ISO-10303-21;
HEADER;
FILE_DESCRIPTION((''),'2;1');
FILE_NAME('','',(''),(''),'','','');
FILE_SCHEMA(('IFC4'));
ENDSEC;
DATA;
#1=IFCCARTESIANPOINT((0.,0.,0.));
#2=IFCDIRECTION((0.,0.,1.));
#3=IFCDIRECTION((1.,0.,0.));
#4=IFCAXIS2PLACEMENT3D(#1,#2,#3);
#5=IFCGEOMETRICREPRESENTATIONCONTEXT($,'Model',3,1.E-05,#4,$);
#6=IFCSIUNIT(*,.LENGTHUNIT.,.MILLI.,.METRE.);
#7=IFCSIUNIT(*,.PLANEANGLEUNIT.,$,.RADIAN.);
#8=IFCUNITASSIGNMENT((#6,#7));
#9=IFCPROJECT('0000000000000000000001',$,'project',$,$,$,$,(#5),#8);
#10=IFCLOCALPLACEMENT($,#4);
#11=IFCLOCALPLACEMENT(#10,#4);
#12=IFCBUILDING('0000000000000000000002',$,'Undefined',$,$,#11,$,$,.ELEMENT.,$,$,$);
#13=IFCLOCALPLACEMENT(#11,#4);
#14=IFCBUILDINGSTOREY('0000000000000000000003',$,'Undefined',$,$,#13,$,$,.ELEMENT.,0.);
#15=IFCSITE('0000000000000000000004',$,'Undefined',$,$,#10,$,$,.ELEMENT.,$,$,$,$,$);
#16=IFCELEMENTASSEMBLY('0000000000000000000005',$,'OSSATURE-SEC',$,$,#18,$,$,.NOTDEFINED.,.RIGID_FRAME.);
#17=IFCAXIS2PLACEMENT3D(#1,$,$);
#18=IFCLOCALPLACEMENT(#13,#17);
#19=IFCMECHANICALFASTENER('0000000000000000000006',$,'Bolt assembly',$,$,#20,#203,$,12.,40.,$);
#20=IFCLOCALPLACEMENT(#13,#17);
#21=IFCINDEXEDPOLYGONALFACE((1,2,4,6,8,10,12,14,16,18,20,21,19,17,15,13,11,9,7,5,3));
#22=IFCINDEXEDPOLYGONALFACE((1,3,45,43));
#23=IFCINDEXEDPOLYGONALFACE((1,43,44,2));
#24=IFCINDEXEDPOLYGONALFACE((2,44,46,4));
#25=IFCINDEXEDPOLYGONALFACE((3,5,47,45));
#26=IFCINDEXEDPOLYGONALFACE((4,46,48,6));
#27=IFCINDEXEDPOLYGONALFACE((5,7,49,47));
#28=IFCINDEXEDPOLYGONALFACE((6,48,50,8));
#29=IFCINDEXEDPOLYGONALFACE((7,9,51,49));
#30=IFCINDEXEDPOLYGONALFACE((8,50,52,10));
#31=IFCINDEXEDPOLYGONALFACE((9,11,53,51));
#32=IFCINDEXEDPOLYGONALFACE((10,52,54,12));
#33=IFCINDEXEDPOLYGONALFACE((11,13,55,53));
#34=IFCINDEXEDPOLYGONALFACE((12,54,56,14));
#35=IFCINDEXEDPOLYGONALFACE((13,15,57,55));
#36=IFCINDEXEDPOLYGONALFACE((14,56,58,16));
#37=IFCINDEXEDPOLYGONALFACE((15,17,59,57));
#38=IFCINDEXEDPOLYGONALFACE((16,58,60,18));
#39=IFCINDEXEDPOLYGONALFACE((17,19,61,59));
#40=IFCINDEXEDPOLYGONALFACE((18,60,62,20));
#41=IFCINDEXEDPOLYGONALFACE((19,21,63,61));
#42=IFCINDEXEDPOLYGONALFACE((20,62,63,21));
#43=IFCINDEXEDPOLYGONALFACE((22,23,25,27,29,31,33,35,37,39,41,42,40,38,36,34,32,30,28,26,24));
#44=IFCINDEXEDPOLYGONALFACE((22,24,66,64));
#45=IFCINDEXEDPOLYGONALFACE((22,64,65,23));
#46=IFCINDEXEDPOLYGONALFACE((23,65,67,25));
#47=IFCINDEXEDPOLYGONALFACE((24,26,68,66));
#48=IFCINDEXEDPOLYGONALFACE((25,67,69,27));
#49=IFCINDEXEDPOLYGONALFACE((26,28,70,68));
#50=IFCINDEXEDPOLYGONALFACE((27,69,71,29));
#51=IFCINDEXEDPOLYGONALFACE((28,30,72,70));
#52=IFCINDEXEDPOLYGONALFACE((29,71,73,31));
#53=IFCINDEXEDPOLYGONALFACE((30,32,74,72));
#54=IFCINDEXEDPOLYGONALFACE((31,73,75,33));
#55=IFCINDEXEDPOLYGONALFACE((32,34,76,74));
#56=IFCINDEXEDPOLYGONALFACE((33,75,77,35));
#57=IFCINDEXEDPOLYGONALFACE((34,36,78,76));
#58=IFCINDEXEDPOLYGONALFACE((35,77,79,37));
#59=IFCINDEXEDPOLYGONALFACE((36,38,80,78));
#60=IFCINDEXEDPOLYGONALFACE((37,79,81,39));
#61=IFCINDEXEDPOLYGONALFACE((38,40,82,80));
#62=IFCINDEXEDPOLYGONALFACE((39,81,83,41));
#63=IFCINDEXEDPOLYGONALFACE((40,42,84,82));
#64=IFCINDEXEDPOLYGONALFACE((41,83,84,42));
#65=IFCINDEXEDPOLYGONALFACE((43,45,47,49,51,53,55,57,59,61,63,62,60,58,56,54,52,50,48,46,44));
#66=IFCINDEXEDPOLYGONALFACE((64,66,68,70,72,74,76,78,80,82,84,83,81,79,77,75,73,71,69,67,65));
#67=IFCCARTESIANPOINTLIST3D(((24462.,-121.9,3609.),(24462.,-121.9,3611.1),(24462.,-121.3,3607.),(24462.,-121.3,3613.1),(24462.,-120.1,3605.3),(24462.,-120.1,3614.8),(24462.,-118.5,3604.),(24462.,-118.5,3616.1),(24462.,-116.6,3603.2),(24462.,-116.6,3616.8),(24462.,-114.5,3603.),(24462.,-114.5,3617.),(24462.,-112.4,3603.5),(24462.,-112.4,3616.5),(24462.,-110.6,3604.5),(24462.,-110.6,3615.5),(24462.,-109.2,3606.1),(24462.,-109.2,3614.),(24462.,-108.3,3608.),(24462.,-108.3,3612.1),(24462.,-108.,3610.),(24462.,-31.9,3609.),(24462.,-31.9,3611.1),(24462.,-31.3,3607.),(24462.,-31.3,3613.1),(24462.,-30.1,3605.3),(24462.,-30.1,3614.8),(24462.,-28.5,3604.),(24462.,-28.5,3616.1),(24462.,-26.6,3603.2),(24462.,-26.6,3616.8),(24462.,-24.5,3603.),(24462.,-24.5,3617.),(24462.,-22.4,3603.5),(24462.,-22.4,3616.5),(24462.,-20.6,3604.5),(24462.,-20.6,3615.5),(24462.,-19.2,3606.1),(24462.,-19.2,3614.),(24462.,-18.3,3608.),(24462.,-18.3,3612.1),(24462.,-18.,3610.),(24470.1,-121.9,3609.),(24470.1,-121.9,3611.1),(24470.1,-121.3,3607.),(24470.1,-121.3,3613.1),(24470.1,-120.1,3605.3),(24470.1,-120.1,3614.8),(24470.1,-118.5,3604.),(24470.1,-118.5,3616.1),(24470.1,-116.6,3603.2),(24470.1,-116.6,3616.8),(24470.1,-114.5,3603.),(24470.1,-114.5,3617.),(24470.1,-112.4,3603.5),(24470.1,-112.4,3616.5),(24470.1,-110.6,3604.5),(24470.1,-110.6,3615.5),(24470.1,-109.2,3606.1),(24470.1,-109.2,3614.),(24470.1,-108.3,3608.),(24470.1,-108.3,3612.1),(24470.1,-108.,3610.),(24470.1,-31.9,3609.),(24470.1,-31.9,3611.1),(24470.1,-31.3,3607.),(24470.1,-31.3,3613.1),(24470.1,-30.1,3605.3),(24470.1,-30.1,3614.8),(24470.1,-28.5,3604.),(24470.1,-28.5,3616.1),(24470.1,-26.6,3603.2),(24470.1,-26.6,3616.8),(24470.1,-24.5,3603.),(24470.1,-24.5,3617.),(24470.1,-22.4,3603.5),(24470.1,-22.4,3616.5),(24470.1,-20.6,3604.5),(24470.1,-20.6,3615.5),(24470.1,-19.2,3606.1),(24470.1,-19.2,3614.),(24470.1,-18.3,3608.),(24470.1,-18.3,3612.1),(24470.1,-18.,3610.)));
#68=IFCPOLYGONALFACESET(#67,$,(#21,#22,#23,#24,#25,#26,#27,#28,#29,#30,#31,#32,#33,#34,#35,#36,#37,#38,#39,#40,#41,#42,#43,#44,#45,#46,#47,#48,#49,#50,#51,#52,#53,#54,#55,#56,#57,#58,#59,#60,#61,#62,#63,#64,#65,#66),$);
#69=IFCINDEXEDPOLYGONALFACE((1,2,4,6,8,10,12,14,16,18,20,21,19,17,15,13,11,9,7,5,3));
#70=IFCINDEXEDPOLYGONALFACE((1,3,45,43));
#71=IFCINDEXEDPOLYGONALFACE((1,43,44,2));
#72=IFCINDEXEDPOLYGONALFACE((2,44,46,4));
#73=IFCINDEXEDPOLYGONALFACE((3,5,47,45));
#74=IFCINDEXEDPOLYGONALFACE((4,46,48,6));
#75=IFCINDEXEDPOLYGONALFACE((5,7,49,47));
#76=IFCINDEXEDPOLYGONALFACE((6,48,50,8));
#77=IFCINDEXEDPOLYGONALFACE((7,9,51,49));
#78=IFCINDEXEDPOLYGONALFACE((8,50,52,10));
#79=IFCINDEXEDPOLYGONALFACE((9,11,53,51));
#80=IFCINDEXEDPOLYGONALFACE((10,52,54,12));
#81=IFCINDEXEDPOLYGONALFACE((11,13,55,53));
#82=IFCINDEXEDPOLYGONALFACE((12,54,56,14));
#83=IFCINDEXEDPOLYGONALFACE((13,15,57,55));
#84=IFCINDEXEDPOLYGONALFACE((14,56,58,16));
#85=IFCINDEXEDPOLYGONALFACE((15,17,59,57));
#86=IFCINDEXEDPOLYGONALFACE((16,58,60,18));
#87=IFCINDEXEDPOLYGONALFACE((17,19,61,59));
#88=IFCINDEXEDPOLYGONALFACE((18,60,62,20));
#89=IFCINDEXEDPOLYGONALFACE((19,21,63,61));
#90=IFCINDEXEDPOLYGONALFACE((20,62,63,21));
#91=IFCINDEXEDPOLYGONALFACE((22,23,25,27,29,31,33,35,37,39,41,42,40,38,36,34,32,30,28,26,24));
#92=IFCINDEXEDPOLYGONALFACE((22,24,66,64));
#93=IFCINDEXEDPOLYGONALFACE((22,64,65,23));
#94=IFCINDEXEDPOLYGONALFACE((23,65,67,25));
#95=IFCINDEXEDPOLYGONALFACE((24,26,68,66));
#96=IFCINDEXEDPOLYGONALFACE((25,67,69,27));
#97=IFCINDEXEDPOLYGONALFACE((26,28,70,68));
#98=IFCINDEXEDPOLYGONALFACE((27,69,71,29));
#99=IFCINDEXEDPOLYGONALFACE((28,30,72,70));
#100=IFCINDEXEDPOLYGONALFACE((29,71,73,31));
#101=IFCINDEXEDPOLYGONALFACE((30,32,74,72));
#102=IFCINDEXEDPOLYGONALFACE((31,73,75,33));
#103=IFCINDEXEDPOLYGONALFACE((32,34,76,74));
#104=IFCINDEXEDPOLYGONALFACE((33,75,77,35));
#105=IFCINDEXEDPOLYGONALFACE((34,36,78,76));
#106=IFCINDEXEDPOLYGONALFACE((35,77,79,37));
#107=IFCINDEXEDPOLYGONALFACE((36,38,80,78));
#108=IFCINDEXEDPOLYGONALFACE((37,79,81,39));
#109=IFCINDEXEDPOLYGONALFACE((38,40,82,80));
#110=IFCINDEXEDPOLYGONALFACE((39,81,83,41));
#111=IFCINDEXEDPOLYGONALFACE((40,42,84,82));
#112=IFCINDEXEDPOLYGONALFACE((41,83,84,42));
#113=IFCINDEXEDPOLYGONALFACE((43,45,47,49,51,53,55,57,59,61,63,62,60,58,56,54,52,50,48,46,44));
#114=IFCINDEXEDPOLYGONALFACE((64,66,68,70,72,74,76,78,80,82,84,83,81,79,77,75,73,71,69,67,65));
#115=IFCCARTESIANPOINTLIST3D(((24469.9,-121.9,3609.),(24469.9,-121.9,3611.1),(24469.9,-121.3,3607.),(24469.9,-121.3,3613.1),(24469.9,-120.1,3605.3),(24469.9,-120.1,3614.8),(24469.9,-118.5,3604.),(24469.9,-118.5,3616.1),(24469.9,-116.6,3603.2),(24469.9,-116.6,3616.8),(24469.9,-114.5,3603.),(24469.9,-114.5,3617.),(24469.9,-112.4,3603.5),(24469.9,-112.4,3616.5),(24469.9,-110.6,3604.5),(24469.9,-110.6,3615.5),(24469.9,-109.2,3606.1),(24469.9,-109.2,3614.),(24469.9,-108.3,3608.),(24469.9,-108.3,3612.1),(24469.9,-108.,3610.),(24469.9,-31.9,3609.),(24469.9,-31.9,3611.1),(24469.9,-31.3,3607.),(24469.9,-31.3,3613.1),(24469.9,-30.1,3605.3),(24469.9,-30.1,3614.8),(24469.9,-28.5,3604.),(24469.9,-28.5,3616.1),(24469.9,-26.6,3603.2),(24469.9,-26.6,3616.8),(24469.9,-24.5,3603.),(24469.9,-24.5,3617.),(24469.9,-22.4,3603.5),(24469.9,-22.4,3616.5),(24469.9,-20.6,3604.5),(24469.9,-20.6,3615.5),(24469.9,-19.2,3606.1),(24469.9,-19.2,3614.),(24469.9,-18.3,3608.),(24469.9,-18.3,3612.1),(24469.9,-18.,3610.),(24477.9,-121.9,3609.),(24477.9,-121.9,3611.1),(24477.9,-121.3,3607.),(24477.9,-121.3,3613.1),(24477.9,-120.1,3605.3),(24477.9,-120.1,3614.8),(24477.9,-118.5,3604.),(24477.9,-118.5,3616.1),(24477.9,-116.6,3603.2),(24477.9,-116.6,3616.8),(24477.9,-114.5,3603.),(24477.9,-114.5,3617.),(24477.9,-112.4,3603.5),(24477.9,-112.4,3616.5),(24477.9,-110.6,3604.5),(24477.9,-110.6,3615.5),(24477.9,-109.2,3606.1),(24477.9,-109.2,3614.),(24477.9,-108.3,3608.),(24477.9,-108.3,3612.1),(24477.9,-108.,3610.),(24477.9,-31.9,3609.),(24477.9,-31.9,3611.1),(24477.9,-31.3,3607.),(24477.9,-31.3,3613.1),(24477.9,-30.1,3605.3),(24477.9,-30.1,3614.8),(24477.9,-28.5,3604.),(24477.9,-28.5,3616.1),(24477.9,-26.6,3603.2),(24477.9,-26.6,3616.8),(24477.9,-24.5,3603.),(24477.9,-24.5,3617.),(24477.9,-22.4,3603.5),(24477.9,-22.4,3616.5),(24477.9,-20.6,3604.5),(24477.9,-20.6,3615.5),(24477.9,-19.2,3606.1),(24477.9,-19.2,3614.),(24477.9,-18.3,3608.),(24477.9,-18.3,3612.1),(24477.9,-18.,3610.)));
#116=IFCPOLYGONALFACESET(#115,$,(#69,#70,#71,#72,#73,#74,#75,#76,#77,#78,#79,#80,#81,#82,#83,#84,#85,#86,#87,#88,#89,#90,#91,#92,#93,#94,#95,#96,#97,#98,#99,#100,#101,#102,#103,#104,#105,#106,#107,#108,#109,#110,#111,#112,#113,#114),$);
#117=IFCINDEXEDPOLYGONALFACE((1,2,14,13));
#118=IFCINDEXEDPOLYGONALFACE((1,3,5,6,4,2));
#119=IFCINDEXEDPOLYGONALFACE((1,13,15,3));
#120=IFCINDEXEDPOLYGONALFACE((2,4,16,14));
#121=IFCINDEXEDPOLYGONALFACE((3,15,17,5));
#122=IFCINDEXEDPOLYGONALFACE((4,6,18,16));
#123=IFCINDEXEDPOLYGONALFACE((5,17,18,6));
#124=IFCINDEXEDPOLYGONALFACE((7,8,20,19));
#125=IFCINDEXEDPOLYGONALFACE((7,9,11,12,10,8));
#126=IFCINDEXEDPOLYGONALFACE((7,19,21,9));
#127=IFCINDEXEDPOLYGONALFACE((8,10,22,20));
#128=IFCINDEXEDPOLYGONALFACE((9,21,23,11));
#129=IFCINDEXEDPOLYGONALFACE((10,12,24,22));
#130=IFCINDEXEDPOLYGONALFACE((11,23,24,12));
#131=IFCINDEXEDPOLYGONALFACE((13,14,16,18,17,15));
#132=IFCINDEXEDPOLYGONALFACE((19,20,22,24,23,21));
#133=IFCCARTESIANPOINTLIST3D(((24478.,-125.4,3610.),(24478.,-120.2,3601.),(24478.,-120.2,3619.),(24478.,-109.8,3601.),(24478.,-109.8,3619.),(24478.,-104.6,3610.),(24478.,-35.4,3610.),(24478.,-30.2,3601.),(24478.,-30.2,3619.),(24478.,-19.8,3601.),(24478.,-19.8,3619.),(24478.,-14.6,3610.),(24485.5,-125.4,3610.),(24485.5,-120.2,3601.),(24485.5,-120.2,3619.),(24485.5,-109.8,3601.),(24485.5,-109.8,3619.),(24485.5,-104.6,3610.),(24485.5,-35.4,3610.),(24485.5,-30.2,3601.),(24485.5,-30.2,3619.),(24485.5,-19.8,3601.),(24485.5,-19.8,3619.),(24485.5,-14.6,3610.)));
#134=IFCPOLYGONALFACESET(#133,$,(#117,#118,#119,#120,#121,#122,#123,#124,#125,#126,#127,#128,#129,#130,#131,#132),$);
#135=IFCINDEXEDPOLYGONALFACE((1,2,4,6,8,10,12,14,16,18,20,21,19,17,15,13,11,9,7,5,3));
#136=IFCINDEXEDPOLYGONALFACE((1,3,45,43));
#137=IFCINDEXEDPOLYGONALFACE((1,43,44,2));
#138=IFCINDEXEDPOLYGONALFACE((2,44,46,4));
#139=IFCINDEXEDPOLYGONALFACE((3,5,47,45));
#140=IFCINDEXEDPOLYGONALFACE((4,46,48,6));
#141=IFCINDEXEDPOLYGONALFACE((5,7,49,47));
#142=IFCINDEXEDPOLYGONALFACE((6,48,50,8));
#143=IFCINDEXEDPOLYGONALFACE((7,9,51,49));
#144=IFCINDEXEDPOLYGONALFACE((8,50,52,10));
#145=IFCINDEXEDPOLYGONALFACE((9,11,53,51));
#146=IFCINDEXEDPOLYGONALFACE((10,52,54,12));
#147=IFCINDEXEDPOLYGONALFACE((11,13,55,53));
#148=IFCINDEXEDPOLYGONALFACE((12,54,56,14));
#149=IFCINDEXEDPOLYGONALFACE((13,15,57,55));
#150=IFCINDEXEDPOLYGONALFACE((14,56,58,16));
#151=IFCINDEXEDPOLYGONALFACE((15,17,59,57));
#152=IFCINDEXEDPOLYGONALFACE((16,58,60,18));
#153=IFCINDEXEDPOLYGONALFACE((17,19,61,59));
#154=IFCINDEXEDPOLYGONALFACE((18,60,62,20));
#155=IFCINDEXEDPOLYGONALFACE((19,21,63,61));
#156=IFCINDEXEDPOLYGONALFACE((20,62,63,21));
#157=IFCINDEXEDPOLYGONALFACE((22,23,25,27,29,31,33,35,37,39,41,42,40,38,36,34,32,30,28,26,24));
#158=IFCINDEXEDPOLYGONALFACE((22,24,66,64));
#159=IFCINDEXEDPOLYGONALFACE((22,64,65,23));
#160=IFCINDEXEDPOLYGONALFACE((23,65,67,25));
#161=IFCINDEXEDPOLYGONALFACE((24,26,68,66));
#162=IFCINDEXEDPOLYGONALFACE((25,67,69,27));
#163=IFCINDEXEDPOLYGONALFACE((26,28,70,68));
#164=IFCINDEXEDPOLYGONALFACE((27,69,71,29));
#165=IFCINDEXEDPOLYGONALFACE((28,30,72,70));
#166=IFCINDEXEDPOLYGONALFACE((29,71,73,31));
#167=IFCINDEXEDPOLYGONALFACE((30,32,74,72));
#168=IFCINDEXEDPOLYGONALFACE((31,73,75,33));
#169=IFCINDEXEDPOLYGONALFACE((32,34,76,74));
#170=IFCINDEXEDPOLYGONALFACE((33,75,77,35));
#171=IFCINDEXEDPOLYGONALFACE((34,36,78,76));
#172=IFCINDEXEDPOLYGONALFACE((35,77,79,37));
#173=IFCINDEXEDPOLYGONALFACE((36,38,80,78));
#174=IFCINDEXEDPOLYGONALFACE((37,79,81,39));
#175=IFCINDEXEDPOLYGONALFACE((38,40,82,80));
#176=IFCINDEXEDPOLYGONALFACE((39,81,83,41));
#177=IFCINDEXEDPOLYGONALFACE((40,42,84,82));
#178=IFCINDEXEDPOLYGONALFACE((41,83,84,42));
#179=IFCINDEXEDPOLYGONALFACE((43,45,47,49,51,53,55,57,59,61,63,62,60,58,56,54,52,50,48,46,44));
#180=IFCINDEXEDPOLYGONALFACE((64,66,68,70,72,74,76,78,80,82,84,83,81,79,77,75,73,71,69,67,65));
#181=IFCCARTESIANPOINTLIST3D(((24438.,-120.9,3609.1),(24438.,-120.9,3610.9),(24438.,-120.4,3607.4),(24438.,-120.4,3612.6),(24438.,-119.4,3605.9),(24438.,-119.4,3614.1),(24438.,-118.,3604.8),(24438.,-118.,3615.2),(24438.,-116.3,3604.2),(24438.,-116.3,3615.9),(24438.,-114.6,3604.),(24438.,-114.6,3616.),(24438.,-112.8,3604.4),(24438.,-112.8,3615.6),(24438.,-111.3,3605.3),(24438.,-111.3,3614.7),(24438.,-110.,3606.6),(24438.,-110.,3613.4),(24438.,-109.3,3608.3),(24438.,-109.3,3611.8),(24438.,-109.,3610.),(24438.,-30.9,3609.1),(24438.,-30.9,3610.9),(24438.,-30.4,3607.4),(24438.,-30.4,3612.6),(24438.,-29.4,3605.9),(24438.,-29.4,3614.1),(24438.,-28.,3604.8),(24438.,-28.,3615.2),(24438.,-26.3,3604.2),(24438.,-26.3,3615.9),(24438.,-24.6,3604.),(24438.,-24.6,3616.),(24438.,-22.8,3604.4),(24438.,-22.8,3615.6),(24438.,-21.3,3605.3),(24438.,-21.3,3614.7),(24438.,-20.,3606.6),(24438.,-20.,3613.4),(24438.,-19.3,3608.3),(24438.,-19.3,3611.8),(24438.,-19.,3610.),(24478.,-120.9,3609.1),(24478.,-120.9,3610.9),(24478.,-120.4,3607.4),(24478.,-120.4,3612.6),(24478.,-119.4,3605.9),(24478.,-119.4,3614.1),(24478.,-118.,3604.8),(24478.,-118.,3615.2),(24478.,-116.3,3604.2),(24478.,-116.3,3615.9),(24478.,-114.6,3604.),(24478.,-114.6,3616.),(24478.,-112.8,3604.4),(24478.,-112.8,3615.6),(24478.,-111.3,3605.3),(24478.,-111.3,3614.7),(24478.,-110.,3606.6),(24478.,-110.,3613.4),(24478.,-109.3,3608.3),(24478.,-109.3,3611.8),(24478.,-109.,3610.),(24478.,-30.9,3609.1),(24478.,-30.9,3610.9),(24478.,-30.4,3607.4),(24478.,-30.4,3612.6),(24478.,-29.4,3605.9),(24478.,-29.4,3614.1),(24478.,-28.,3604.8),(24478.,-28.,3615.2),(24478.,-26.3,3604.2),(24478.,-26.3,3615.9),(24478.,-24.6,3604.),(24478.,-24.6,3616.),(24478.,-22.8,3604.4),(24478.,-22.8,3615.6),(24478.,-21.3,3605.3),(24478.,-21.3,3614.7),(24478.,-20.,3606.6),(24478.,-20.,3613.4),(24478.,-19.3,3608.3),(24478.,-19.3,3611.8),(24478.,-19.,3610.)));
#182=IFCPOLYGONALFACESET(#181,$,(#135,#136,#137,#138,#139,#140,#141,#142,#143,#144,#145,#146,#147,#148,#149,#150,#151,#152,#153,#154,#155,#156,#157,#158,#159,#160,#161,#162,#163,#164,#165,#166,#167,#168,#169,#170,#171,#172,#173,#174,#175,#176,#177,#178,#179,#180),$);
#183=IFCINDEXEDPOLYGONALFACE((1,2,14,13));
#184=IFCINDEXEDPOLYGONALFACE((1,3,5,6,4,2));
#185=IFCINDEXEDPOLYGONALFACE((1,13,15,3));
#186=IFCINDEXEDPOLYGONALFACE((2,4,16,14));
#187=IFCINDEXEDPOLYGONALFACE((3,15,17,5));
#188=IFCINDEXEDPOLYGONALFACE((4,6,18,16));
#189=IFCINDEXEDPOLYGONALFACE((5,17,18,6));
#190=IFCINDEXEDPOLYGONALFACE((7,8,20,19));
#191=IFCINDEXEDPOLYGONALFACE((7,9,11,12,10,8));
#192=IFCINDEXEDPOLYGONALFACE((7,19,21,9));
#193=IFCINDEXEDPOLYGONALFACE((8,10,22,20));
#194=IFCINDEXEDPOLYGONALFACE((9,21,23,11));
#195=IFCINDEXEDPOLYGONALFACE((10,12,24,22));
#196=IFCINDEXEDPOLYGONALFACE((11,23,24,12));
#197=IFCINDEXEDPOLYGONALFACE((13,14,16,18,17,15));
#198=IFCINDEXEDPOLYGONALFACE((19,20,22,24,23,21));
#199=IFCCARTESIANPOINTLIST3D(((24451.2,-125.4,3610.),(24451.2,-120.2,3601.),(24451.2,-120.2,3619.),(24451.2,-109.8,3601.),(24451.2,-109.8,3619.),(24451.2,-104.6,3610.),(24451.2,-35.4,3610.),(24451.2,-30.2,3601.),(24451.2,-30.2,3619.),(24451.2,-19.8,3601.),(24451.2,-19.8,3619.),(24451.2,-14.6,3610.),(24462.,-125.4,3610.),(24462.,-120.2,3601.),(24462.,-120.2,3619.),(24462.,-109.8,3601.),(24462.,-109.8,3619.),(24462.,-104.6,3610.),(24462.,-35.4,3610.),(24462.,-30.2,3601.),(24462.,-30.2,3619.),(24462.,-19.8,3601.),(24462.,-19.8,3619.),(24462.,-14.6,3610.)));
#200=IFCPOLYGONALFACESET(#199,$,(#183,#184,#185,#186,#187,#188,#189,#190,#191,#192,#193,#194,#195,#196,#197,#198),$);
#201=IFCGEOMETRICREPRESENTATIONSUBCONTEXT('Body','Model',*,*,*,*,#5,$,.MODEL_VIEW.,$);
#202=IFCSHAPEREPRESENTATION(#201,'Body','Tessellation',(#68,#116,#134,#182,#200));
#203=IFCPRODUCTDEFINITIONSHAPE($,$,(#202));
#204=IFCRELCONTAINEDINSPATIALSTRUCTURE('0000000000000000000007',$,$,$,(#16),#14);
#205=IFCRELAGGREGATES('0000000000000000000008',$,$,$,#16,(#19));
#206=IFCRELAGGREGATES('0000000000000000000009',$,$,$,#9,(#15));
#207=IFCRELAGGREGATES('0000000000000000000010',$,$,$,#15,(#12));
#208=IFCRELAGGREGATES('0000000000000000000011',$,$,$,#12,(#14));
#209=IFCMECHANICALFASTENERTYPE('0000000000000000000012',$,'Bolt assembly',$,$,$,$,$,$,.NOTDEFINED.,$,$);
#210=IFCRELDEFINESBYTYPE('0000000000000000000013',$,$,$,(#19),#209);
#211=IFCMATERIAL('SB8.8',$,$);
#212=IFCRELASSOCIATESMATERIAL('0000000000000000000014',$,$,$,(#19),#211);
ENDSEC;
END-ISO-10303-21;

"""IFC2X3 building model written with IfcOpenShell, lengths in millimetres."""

from ifc_helpers import new_model, si_unit, frame, origin_with_axes, origin_2d_with_axis, place, context, subcontext, project, spatial, polyline, circle, outline, extrude, source, transform, mapped, material, type_object, element, aggregate, save


model = new_model("IFC2X3")

# Units and contexts
model_context = context("Model", 3, precision=1e-05, world=origin_with_axes())
body_context = subcontext(model_context, "Body", "Model", "MODEL_VIEW")
ifc_project = project(units=[si_unit("LENGTHUNIT", "METRE", prefix="MILLI"), si_unit("PLANEANGLEUNIT", "RADIAN")], contexts=[model_context])

# Site, building, storey
site_placement = place(None, origin_with_axes())
site = spatial("IfcSite", under=ifc_project, at=site_placement, Name="Undefined", CompositionType="ELEMENT")
building_placement = place(site_placement, origin_with_axes())
building = spatial("IfcBuilding", under=site, at=building_placement, Name="Undefined", CompositionType="ELEMENT")
storey_placement = place(building_placement, origin_with_axes())
storey = spatial("IfcBuildingStorey", under=building, at=storey_placement, Name="Undefined", CompositionType="ELEMENT", Elevation=0.0)

# Element assembly
assembly_1_placement = place(storey_placement, origin_with_axes())
assembly_1 = element("IfcElementAssembly", 1, at=assembly_1_placement, inside=storey, Name="OSSATURE-SEC", AssemblyPlace="NOTDEFINED", PredefinedType="RIGID_FRAME")

# Mechanical fastener
ifc_material_1 = material(Name="SB8.8")
mechanical_fastener_type = type_object("IfcMechanicalFastenerType", Name="Bolt assembly")
shared_shape_1 = source(origin_with_axes(), body_context, "Body", "SweptSolid", [
    extrude(circle(Radius=7.0, at=origin_2d_with_axis()), frame((0.0, 0.2, 0.0), z_axis=(0.0, 1.0, 0.0), x_axis=(1.0, 0.0, 0.0)), (0.0, 0.0, 1.0), 8.1),
    extrude(circle(Radius=7.0, at=origin_2d_with_axis()), frame((0.0, -7.6, 0.0), z_axis=(0.0, 1.0, 0.0), x_axis=(1.0, 0.0, 0.0)), (0.0, 0.0, 1.0), 8.0),
    extrude(outline(polyline([(10.4, 0.0), (5.2, 9.0), (-5.2, 9.0), (-10.4, 0.0), (-5.2, -9.0), (5.2, -9.0), (10.4, 0.0)])), frame((0.0, -15.2, 0.0), z_axis=(0.0, 1.0, 0.0), x_axis=(1.0, 0.0, 0.0)), (0.0, 0.0, 1.0), 7.5),
    extrude(circle(Radius=6.0, at=origin_2d_with_axis()), frame((0.0, -7.7, 0.0), z_axis=(0.0, 1.0, 0.0), x_axis=(1.0, 0.0, 0.0)), (0.0, 0.0, 1.0), 40.0),
    extrude(outline(polyline([(10.4, 0.0), (5.2, 9.0), (-5.2, 9.0), (-10.4, 0.0), (-5.2, -9.0), (5.2, -9.0), (10.4, 0.0)])), frame((0.0, 8.3, 0.0), z_axis=(0.0, 1.0, 0.0), x_axis=(1.0, 0.0, 0.0)), (0.0, 0.0, 1.0), 10.8),
])
mechanical_fastener_1_placement = place(assembly_1_placement, frame((24470.3, -115.0, 3610.0), z_axis=(0.0, 0.0, 1.0), x_axis=(0.0, 1.0, 0.0)))
mechanical_fastener_1 = element("IfcMechanicalFastener", 2, at=mechanical_fastener_1_placement, type_object=mechanical_fastener_type, material=ifc_material_1, Name="Bolt assembly", NominalDiameter=12.0, NominalLength=40.0, context=body_context, shape_type="MappedRepresentation", body=[
    mapped(shared_shape_1, transform((0.0, 0.0, 0.0))),
    mapped(shared_shape_1, transform((90.0, 0.0, 0.0))),
])
aggregate(assembly_1, [mechanical_fastener_1])

save(model, "model.ifc")
